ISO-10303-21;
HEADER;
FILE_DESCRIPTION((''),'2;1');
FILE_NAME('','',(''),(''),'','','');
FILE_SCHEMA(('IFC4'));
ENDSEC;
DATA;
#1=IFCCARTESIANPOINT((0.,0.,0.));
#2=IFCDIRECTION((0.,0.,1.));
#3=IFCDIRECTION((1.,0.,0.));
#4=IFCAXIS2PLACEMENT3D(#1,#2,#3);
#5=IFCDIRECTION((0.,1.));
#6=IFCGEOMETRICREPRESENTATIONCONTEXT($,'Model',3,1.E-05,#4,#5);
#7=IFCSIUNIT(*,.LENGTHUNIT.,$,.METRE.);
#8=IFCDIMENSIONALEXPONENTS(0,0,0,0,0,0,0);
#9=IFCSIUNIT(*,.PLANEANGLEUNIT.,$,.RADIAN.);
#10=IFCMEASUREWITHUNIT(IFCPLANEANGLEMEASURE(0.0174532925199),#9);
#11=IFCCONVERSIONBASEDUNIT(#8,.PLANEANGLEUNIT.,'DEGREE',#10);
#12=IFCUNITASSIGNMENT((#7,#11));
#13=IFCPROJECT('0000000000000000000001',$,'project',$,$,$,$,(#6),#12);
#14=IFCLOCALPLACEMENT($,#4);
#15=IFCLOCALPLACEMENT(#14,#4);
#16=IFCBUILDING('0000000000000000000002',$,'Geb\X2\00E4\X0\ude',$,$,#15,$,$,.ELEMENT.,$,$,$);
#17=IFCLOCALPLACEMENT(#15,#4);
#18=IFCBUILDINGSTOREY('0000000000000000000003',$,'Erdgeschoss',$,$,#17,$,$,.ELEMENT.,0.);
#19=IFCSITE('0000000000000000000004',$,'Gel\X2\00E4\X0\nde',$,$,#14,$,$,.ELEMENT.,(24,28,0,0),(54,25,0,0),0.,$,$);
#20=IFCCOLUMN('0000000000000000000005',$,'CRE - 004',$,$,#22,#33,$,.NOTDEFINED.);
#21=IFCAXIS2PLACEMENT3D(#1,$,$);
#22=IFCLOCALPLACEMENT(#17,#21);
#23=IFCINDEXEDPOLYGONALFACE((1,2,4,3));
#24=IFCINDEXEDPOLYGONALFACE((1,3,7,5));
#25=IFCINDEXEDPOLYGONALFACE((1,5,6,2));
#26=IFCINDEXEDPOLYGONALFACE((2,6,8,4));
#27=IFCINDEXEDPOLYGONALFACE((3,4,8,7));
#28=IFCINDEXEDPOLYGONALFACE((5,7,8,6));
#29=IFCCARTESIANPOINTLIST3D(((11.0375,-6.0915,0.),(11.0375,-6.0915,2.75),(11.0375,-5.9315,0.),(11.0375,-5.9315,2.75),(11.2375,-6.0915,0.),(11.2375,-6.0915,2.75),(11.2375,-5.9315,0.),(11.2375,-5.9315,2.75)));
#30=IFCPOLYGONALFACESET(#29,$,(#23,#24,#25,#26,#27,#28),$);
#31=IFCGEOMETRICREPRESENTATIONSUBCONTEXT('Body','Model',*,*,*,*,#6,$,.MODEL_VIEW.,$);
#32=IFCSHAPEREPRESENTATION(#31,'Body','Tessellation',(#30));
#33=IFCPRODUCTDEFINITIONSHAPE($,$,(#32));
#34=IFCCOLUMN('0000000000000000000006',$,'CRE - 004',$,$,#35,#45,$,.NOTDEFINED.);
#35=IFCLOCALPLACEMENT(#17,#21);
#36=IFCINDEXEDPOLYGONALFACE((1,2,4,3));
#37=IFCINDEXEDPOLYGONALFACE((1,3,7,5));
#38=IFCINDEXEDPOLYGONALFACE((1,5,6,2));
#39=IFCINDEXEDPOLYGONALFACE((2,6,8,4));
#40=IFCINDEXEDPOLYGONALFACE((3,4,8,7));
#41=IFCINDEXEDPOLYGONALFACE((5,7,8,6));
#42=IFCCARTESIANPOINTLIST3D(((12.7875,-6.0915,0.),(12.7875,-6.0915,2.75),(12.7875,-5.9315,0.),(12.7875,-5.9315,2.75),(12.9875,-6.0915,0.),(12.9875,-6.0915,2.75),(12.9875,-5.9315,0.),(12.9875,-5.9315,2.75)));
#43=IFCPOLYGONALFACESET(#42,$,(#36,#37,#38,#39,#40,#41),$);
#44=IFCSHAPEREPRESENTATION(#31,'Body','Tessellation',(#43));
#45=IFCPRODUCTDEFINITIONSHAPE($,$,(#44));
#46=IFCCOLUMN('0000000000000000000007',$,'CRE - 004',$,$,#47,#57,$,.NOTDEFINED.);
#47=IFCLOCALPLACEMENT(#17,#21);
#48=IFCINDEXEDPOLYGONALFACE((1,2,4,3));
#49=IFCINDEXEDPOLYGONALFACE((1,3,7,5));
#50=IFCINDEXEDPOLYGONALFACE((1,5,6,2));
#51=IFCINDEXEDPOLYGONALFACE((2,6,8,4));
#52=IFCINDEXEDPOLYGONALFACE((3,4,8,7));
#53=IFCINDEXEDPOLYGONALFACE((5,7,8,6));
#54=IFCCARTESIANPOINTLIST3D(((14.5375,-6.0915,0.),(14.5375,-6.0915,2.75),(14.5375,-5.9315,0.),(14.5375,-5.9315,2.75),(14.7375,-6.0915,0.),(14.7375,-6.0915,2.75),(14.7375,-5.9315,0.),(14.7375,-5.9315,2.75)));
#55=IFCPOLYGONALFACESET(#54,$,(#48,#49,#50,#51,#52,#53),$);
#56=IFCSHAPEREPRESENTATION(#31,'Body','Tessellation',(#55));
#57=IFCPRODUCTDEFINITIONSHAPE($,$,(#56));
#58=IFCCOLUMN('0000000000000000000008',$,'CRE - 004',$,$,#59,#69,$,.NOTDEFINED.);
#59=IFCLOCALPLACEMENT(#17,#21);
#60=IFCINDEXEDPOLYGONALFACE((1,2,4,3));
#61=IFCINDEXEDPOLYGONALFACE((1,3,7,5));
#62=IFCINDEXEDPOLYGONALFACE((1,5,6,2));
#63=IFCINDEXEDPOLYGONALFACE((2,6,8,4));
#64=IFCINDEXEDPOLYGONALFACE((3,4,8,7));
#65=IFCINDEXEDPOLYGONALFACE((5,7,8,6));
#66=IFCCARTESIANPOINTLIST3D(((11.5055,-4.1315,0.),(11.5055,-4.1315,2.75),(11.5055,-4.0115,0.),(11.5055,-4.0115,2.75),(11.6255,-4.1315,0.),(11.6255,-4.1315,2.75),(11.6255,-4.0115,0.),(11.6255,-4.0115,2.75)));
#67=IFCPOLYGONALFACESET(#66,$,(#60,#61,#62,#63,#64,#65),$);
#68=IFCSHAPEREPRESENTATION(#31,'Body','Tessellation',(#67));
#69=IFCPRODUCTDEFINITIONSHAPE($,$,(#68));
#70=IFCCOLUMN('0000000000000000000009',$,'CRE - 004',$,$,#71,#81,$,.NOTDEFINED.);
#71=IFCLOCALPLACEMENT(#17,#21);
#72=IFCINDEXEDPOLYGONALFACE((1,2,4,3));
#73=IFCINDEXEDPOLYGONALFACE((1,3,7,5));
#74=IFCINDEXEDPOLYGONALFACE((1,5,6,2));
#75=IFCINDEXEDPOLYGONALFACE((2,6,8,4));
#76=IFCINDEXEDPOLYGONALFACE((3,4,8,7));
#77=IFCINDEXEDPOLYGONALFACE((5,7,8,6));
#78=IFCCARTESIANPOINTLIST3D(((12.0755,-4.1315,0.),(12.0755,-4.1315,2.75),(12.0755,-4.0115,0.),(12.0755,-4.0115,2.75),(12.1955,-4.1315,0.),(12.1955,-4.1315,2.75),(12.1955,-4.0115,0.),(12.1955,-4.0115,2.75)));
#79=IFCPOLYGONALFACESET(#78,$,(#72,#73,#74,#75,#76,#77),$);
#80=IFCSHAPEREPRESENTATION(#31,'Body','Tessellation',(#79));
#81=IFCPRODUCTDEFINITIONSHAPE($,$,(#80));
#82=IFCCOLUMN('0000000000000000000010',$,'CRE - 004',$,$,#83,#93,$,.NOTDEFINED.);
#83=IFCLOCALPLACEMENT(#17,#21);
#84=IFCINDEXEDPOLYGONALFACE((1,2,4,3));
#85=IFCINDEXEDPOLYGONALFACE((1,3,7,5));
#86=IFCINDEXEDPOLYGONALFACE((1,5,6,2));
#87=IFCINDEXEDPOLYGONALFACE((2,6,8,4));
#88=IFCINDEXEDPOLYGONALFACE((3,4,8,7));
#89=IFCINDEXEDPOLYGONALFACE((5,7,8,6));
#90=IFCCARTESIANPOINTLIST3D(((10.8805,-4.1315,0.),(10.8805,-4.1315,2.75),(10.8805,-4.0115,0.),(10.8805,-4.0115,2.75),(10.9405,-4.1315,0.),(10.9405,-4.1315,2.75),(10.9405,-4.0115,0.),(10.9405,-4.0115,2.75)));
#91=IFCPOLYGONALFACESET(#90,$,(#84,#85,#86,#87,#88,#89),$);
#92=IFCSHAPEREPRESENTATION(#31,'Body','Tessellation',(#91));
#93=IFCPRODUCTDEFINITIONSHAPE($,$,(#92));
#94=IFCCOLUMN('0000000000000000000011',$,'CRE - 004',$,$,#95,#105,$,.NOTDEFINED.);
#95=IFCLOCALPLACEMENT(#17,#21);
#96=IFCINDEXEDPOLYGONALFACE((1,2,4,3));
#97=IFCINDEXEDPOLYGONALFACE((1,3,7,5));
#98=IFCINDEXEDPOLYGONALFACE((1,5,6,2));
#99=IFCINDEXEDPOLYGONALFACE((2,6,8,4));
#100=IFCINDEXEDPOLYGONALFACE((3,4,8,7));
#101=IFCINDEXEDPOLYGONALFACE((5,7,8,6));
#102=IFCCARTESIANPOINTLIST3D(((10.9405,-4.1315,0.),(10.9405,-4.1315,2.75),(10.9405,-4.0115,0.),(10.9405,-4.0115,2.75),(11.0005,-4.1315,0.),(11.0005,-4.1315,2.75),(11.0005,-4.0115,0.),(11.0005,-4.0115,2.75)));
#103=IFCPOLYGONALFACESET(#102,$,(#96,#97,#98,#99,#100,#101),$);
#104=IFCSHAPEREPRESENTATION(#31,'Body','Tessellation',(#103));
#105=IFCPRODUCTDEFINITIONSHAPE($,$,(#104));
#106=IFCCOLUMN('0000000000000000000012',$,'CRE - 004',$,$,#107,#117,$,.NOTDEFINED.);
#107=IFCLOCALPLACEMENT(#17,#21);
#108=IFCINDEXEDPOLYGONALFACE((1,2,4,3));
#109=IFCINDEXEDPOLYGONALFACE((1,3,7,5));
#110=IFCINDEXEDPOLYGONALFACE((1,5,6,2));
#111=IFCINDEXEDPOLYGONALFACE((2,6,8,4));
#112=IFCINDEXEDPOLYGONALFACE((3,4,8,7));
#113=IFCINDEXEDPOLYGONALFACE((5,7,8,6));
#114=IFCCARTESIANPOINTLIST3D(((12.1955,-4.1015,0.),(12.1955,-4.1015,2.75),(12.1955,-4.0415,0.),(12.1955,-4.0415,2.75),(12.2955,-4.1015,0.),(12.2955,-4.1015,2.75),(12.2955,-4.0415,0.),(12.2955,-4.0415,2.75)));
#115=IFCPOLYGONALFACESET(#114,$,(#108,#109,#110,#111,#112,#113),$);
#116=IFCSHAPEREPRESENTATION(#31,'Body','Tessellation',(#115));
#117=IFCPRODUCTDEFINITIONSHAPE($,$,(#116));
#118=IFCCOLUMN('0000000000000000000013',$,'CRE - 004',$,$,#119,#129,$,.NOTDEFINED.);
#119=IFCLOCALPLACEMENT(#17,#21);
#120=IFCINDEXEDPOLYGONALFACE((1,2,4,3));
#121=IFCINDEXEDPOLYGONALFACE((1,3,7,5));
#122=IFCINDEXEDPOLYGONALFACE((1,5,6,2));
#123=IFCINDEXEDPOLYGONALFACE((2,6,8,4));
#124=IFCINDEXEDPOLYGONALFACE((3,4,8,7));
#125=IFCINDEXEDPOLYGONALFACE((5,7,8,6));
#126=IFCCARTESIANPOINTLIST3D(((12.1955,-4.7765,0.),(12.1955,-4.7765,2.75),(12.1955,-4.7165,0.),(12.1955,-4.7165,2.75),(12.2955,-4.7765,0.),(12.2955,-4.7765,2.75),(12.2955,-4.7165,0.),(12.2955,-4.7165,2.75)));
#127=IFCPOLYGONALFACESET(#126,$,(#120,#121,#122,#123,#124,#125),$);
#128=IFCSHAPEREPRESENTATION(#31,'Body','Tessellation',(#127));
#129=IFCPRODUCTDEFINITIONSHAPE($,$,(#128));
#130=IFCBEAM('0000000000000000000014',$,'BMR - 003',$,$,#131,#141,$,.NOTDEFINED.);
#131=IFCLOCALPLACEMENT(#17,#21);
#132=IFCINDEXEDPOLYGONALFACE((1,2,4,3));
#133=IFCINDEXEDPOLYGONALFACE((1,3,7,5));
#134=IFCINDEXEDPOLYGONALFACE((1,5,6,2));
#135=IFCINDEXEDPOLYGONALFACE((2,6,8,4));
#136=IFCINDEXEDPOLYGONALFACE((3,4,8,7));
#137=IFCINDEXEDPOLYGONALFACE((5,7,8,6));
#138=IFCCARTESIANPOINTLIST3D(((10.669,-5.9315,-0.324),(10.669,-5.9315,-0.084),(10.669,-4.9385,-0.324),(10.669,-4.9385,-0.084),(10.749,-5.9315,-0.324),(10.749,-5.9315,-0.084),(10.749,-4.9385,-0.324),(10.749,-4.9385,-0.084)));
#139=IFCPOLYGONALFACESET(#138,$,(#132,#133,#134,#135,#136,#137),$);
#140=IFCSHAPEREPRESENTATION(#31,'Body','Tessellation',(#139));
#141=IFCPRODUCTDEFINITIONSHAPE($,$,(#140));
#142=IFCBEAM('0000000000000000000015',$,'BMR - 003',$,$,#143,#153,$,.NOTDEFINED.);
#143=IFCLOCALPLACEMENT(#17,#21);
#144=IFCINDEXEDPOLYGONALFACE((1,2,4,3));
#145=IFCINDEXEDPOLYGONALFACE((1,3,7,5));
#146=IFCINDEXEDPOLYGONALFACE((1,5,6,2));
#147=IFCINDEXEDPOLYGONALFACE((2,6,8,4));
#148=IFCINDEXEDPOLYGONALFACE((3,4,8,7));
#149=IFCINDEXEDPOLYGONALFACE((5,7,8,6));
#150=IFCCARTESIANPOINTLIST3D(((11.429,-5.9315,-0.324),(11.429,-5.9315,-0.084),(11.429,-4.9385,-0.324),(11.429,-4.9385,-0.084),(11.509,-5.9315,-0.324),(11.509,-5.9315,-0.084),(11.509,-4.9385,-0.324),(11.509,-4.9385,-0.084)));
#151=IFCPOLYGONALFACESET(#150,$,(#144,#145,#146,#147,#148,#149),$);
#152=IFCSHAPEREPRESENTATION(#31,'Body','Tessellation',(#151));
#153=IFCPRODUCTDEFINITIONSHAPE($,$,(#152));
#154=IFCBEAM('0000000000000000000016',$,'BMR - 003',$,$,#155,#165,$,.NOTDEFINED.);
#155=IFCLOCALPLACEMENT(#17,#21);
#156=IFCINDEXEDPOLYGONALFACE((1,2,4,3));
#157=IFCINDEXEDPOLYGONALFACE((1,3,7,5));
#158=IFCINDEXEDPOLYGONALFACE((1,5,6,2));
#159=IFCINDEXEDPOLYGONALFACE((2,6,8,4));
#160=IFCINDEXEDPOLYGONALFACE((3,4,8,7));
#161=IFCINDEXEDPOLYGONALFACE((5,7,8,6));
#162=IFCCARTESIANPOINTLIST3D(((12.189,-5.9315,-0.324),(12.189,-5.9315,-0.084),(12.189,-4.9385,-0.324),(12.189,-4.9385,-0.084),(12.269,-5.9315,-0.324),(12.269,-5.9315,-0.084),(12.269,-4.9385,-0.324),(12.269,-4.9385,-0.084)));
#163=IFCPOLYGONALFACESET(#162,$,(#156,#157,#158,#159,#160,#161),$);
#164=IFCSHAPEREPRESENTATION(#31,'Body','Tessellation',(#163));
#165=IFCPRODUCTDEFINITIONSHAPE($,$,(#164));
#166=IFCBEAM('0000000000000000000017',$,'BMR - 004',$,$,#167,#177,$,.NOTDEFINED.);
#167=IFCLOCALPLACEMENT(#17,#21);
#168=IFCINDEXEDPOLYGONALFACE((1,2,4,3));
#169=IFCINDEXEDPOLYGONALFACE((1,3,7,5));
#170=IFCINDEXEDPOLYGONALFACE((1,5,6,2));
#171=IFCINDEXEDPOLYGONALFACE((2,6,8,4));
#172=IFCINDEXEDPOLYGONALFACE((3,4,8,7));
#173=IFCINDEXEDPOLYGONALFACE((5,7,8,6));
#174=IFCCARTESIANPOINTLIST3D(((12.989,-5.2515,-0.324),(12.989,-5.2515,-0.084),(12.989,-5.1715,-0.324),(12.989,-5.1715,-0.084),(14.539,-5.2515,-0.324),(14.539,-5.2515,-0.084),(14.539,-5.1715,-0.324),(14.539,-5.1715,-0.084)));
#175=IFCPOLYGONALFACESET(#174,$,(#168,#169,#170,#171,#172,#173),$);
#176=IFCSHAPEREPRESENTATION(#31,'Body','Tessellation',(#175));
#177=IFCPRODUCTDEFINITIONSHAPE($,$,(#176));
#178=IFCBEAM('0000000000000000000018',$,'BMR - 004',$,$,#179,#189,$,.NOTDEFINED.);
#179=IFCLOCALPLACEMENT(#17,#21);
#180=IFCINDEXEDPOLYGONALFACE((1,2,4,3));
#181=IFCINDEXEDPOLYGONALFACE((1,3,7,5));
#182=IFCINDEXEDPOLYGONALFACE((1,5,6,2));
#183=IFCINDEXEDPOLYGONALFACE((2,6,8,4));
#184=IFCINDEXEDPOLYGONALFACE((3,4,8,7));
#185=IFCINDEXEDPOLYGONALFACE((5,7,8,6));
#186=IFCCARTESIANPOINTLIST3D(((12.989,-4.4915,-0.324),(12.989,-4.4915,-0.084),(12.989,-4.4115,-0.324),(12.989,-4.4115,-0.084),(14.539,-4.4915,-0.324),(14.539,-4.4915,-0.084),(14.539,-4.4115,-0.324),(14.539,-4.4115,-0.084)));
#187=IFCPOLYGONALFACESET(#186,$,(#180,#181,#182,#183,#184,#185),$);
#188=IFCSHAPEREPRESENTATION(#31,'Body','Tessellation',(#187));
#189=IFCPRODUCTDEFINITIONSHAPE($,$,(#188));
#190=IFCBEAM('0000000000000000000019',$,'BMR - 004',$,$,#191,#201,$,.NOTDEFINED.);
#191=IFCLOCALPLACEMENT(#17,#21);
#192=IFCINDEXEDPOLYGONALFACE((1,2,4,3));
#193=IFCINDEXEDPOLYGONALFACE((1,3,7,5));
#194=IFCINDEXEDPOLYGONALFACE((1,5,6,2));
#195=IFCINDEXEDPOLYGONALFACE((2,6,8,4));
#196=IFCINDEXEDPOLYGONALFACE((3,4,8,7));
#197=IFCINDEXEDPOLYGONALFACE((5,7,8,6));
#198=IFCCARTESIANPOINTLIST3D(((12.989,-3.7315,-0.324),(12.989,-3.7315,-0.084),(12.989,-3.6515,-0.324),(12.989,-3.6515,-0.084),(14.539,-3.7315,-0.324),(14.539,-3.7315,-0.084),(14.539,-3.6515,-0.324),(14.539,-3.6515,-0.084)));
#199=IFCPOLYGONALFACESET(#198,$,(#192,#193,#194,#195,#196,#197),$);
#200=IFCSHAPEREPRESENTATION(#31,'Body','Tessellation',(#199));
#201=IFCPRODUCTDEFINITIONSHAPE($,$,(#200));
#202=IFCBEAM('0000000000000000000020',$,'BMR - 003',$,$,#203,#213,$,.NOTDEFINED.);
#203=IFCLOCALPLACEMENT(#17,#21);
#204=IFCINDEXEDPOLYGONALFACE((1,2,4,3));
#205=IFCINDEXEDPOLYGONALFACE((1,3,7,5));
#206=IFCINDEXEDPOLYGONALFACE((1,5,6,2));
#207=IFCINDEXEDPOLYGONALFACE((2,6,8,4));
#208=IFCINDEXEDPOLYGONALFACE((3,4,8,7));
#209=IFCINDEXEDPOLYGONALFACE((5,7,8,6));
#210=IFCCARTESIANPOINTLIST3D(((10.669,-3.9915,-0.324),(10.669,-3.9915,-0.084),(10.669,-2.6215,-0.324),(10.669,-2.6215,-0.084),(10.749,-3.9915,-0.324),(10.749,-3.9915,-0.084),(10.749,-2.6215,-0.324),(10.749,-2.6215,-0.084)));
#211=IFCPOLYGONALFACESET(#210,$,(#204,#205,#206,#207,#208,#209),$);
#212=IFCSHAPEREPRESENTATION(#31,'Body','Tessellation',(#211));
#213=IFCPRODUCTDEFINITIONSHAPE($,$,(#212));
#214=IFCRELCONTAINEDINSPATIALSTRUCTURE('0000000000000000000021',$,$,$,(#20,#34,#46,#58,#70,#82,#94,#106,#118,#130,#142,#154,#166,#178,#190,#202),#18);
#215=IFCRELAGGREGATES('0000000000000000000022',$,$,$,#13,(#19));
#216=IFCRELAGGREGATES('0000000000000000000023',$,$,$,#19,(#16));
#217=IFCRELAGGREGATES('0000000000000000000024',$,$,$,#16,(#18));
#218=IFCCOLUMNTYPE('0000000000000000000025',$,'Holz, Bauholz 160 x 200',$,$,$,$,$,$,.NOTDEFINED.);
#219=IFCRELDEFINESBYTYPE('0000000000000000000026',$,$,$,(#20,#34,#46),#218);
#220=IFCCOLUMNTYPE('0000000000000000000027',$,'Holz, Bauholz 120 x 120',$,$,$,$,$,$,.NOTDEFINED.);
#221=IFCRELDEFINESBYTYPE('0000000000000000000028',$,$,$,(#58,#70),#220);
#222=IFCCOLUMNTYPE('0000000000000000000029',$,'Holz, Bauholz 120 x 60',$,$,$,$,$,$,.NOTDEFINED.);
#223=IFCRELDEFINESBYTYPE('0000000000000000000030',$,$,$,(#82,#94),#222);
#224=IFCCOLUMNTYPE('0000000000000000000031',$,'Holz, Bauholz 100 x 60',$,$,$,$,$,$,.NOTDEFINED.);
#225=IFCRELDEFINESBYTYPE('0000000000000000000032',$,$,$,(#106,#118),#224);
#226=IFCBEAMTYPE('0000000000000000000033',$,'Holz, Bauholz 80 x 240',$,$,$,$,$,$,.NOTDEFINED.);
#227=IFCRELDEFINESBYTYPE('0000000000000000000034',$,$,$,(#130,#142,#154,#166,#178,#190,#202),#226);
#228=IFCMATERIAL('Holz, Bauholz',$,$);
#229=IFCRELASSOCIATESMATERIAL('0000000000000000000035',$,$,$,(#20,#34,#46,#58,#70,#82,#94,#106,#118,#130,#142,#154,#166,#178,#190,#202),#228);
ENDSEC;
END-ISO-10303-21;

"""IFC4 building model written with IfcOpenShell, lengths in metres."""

from ifc_helpers import new_model, entity, si_unit, converted_unit, direction, frame, frame_2d, origin_with_axes, origin_2d_with_axis, place, context, subcontext, project, spatial, rectangle, extrude, material, type_object, element, save


model = new_model("IFC4")

# Units and contexts
model_context = context("Model", 3, precision=1e-05, world=origin_with_axes(), true_north=direction((0.0, 1.0)))
body_context = subcontext(model_context, "Body", "Model", "MODEL_VIEW")
ifc_project = project(units=[si_unit("LENGTHUNIT", "METRE"), converted_unit("PLANEANGLEUNIT", "DEGREE", entity("IfcPlaneAngleMeasure", 0.0174532925199), si_unit("PLANEANGLEUNIT", "RADIAN"), dimensions=[0, 0, 0, 0, 0, 0, 0])], contexts=[model_context])

# Site, building, storey
site_placement = place(None, origin_with_axes())
site = spatial("IfcSite", under=ifc_project, at=site_placement, Name="Gelände", CompositionType="ELEMENT", RefLatitude=(24, 28, 0, 0), RefLongitude=(54, 25, 0, 0), RefElevation=0.0)
building_placement = place(site_placement, origin_with_axes())
building = spatial("IfcBuilding", under=site, at=building_placement, Name="Gebäude", CompositionType="ELEMENT")
storey_placement = place(building_placement, origin_with_axes())
storey = spatial("IfcBuildingStorey", under=building, at=storey_placement, Name="Erdgeschoss", CompositionType="ELEMENT", Elevation=0.0)

# Columns
ifc_material_1 = material(Name="Holz, Bauholz")
column_type_1 = type_object("IfcColumnType", Name="Holz, Bauholz 160 x 200", PredefinedType="NOTDEFINED")
for number, where, z_axis, x_axis, name in (
    (1, (11.1375, -6.0115, 0.0), (0.0, 0.0, 1.0), (1.0, 0.0, 0.0), "CRE - 004"),
    (2, (12.8875, -6.0115, 0.0), (0.0, 0.0, 1.0), (1.0, 0.0, 0.0), "CRE - 004"),
    (3, (14.6375, -6.0115, 0.0), (0.0, 0.0, 1.0), (1.0, 0.0, 0.0), "CRE - 004"),
):
    element("IfcColumn", number, at=place(storey_placement, frame(where, z_axis=z_axis, x_axis=x_axis)), inside=storey, type_object=column_type_1, material=ifc_material_1, Name=name, PredefinedType="NOTDEFINED", context=body_context, shape_type="SweptSolid", body=[
        extrude(rectangle(XDim=0.16, YDim=0.2, at=origin_2d_with_axis()), frame((0.0, 0.0, 0.0), z_axis=(0.0, 0.0, 1.0), x_axis=(0.0, 1.0, 0.0)), (0.0, 0.0, 1.0), 2.75),
    ])
column_type_2 = type_object("IfcColumnType", Name="Holz, Bauholz 120 x 120", PredefinedType="NOTDEFINED")
for number, where, z_axis, x_axis, name in (
    (4, (11.5655, -4.0715, 0.0), (0.0, 0.0, 1.0), (1.0, 0.0, 0.0), "CRE - 004"),
    (5, (12.1355, -4.0715, 0.0), (0.0, 0.0, 1.0), (1.0, 0.0, 0.0), "CRE - 004"),
):
    element("IfcColumn", number, at=place(storey_placement, frame(where, z_axis=z_axis, x_axis=x_axis)), inside=storey, type_object=column_type_2, material=ifc_material_1, Name=name, PredefinedType="NOTDEFINED", context=body_context, shape_type="SweptSolid", body=[
        extrude(rectangle(XDim=0.12, YDim=0.12, at=origin_2d_with_axis()), frame((0.0, 0.0, 0.0), z_axis=(0.0, 0.0, 1.0), x_axis=(0.0, 1.0, 0.0)), (0.0, 0.0, 1.0), 2.75),
    ])
column_type_3 = type_object("IfcColumnType", Name="Holz, Bauholz 120 x 60", PredefinedType="NOTDEFINED")
for number, where, z_axis, x_axis, name in (
    (6, (10.9105, -4.0715, 0.0), (0.0, 0.0, 1.0), (1.0, 0.0, 0.0), "CRE - 004"),
    (7, (10.9705, -4.0715, 0.0), (0.0, 0.0, 1.0), (1.0, 0.0, 0.0), "CRE - 004"),
):
    element("IfcColumn", number, at=place(storey_placement, frame(where, z_axis=z_axis, x_axis=x_axis)), inside=storey, type_object=column_type_3, material=ifc_material_1, Name=name, PredefinedType="NOTDEFINED", context=body_context, shape_type="SweptSolid", body=[
        extrude(rectangle(XDim=0.12, YDim=0.06, at=origin_2d_with_axis()), frame((0.0, 0.0, 0.0), z_axis=(0.0, 0.0, 1.0), x_axis=(0.0, 1.0, 0.0)), (0.0, 0.0, 1.0), 2.75),
    ])
column_type_4 = type_object("IfcColumnType", Name="Holz, Bauholz 100 x 60", PredefinedType="NOTDEFINED")
for number, where, z_axis, x_axis, name in (
    (8, (12.2455, -4.0715, 0.0), (0.0, 0.0, 1.0), (0.0, -1.0, 0.0), "CRE - 004"),
    (9, (12.2455, -4.7465, 0.0), (0.0, 0.0, 1.0), (0.0, -1.0, 0.0), "CRE - 004"),
):
    element("IfcColumn", number, at=place(storey_placement, frame(where, z_axis=z_axis, x_axis=x_axis)), inside=storey, type_object=column_type_4, material=ifc_material_1, Name=name, PredefinedType="NOTDEFINED", context=body_context, shape_type="SweptSolid", body=[
        extrude(rectangle(XDim=0.1, YDim=0.06, at=origin_2d_with_axis()), frame((0.0, 0.0, 0.0), z_axis=(0.0, 0.0, 1.0), x_axis=(0.0, 1.0, 0.0)), (0.0, 0.0, 1.0), 2.75),
    ])

# Beams
beam_type_1 = type_object("IfcBeamType", Name="Holz, Bauholz 80 x 240", PredefinedType="NOTDEFINED")
for number, where, z_axis, x_axis, name in (
    (10, (10.709, -5.9315, -0.084), (0.0, 0.0, 1.0), (1.0, 0.0, 0.0), "BMR - 003"),
    (11, (11.469, -5.9315, -0.084), (0.0, 0.0, 1.0), (1.0, 0.0, 0.0), "BMR - 003"),
    (12, (12.229, -5.9315, -0.084), (0.0, 0.0, 1.0), (1.0, 0.0, 0.0), "BMR - 003"),
):
    element("IfcBeam", number, at=place(storey_placement, frame(where, z_axis=z_axis, x_axis=x_axis)), inside=storey, type_object=beam_type_1, material=ifc_material_1, Name=name, PredefinedType="NOTDEFINED", context=body_context, shape_type="SweptSolid", body=[
        extrude(rectangle(XDim=0.24, YDim=0.08, at=frame_2d((-0.12, 0.0), x_axis=(1.0, 0.0))), frame((0.0, 0.0, 0.0), z_axis=(0.0, 1.0, 0.0), x_axis=(0.0, 0.0, 1.0)), (0.0, 0.0, 1.0), 0.993),
    ])
for number, where, z_axis, x_axis, name in (
    (13, (14.539, -5.2115, -0.084), (0.0, 0.0, 1.0), (0.0, 1.0, 0.0), "BMR - 004"),
    (14, (14.539, -4.4515, -0.084), (0.0, 0.0, 1.0), (0.0, 1.0, 0.0), "BMR - 004"),
    (15, (14.539, -3.6915, -0.084), (0.0, 0.0, 1.0), (0.0, 1.0, 0.0), "BMR - 004"),
):
    element("IfcBeam", number, at=place(storey_placement, frame(where, z_axis=z_axis, x_axis=x_axis)), inside=storey, type_object=beam_type_1, material=ifc_material_1, Name=name, PredefinedType="NOTDEFINED", context=body_context, shape_type="SweptSolid", body=[
        extrude(rectangle(XDim=0.24, YDim=0.08, at=frame_2d((-0.12, 0.0), x_axis=(1.0, 0.0))), frame((0.0, 0.0, 0.0), z_axis=(0.0, 1.0, 0.0), x_axis=(0.0, 0.0, 1.0)), (0.0, 0.0, 1.0), 1.55),
    ])
for number, where, z_axis, x_axis, name in (
    (16, (10.709, -3.9915, -0.084), (0.0, 0.0, 1.0), (1.0, 0.0, 0.0), "BMR - 003"),
):
    element("IfcBeam", number, at=place(storey_placement, frame(where, z_axis=z_axis, x_axis=x_axis)), inside=storey, type_object=beam_type_1, material=ifc_material_1, Name=name, PredefinedType="NOTDEFINED", context=body_context, shape_type="SweptSolid", body=[
        extrude(rectangle(XDim=0.24, YDim=0.08, at=frame_2d((-0.12, 0.0), x_axis=(1.0, 0.0))), frame((0.0, 0.0, 0.0), z_axis=(0.0, 1.0, 0.0), x_axis=(0.0, 0.0, 1.0)), (0.0, 0.0, 1.0), 1.37),
    ])

save(model, "model.ifc")
